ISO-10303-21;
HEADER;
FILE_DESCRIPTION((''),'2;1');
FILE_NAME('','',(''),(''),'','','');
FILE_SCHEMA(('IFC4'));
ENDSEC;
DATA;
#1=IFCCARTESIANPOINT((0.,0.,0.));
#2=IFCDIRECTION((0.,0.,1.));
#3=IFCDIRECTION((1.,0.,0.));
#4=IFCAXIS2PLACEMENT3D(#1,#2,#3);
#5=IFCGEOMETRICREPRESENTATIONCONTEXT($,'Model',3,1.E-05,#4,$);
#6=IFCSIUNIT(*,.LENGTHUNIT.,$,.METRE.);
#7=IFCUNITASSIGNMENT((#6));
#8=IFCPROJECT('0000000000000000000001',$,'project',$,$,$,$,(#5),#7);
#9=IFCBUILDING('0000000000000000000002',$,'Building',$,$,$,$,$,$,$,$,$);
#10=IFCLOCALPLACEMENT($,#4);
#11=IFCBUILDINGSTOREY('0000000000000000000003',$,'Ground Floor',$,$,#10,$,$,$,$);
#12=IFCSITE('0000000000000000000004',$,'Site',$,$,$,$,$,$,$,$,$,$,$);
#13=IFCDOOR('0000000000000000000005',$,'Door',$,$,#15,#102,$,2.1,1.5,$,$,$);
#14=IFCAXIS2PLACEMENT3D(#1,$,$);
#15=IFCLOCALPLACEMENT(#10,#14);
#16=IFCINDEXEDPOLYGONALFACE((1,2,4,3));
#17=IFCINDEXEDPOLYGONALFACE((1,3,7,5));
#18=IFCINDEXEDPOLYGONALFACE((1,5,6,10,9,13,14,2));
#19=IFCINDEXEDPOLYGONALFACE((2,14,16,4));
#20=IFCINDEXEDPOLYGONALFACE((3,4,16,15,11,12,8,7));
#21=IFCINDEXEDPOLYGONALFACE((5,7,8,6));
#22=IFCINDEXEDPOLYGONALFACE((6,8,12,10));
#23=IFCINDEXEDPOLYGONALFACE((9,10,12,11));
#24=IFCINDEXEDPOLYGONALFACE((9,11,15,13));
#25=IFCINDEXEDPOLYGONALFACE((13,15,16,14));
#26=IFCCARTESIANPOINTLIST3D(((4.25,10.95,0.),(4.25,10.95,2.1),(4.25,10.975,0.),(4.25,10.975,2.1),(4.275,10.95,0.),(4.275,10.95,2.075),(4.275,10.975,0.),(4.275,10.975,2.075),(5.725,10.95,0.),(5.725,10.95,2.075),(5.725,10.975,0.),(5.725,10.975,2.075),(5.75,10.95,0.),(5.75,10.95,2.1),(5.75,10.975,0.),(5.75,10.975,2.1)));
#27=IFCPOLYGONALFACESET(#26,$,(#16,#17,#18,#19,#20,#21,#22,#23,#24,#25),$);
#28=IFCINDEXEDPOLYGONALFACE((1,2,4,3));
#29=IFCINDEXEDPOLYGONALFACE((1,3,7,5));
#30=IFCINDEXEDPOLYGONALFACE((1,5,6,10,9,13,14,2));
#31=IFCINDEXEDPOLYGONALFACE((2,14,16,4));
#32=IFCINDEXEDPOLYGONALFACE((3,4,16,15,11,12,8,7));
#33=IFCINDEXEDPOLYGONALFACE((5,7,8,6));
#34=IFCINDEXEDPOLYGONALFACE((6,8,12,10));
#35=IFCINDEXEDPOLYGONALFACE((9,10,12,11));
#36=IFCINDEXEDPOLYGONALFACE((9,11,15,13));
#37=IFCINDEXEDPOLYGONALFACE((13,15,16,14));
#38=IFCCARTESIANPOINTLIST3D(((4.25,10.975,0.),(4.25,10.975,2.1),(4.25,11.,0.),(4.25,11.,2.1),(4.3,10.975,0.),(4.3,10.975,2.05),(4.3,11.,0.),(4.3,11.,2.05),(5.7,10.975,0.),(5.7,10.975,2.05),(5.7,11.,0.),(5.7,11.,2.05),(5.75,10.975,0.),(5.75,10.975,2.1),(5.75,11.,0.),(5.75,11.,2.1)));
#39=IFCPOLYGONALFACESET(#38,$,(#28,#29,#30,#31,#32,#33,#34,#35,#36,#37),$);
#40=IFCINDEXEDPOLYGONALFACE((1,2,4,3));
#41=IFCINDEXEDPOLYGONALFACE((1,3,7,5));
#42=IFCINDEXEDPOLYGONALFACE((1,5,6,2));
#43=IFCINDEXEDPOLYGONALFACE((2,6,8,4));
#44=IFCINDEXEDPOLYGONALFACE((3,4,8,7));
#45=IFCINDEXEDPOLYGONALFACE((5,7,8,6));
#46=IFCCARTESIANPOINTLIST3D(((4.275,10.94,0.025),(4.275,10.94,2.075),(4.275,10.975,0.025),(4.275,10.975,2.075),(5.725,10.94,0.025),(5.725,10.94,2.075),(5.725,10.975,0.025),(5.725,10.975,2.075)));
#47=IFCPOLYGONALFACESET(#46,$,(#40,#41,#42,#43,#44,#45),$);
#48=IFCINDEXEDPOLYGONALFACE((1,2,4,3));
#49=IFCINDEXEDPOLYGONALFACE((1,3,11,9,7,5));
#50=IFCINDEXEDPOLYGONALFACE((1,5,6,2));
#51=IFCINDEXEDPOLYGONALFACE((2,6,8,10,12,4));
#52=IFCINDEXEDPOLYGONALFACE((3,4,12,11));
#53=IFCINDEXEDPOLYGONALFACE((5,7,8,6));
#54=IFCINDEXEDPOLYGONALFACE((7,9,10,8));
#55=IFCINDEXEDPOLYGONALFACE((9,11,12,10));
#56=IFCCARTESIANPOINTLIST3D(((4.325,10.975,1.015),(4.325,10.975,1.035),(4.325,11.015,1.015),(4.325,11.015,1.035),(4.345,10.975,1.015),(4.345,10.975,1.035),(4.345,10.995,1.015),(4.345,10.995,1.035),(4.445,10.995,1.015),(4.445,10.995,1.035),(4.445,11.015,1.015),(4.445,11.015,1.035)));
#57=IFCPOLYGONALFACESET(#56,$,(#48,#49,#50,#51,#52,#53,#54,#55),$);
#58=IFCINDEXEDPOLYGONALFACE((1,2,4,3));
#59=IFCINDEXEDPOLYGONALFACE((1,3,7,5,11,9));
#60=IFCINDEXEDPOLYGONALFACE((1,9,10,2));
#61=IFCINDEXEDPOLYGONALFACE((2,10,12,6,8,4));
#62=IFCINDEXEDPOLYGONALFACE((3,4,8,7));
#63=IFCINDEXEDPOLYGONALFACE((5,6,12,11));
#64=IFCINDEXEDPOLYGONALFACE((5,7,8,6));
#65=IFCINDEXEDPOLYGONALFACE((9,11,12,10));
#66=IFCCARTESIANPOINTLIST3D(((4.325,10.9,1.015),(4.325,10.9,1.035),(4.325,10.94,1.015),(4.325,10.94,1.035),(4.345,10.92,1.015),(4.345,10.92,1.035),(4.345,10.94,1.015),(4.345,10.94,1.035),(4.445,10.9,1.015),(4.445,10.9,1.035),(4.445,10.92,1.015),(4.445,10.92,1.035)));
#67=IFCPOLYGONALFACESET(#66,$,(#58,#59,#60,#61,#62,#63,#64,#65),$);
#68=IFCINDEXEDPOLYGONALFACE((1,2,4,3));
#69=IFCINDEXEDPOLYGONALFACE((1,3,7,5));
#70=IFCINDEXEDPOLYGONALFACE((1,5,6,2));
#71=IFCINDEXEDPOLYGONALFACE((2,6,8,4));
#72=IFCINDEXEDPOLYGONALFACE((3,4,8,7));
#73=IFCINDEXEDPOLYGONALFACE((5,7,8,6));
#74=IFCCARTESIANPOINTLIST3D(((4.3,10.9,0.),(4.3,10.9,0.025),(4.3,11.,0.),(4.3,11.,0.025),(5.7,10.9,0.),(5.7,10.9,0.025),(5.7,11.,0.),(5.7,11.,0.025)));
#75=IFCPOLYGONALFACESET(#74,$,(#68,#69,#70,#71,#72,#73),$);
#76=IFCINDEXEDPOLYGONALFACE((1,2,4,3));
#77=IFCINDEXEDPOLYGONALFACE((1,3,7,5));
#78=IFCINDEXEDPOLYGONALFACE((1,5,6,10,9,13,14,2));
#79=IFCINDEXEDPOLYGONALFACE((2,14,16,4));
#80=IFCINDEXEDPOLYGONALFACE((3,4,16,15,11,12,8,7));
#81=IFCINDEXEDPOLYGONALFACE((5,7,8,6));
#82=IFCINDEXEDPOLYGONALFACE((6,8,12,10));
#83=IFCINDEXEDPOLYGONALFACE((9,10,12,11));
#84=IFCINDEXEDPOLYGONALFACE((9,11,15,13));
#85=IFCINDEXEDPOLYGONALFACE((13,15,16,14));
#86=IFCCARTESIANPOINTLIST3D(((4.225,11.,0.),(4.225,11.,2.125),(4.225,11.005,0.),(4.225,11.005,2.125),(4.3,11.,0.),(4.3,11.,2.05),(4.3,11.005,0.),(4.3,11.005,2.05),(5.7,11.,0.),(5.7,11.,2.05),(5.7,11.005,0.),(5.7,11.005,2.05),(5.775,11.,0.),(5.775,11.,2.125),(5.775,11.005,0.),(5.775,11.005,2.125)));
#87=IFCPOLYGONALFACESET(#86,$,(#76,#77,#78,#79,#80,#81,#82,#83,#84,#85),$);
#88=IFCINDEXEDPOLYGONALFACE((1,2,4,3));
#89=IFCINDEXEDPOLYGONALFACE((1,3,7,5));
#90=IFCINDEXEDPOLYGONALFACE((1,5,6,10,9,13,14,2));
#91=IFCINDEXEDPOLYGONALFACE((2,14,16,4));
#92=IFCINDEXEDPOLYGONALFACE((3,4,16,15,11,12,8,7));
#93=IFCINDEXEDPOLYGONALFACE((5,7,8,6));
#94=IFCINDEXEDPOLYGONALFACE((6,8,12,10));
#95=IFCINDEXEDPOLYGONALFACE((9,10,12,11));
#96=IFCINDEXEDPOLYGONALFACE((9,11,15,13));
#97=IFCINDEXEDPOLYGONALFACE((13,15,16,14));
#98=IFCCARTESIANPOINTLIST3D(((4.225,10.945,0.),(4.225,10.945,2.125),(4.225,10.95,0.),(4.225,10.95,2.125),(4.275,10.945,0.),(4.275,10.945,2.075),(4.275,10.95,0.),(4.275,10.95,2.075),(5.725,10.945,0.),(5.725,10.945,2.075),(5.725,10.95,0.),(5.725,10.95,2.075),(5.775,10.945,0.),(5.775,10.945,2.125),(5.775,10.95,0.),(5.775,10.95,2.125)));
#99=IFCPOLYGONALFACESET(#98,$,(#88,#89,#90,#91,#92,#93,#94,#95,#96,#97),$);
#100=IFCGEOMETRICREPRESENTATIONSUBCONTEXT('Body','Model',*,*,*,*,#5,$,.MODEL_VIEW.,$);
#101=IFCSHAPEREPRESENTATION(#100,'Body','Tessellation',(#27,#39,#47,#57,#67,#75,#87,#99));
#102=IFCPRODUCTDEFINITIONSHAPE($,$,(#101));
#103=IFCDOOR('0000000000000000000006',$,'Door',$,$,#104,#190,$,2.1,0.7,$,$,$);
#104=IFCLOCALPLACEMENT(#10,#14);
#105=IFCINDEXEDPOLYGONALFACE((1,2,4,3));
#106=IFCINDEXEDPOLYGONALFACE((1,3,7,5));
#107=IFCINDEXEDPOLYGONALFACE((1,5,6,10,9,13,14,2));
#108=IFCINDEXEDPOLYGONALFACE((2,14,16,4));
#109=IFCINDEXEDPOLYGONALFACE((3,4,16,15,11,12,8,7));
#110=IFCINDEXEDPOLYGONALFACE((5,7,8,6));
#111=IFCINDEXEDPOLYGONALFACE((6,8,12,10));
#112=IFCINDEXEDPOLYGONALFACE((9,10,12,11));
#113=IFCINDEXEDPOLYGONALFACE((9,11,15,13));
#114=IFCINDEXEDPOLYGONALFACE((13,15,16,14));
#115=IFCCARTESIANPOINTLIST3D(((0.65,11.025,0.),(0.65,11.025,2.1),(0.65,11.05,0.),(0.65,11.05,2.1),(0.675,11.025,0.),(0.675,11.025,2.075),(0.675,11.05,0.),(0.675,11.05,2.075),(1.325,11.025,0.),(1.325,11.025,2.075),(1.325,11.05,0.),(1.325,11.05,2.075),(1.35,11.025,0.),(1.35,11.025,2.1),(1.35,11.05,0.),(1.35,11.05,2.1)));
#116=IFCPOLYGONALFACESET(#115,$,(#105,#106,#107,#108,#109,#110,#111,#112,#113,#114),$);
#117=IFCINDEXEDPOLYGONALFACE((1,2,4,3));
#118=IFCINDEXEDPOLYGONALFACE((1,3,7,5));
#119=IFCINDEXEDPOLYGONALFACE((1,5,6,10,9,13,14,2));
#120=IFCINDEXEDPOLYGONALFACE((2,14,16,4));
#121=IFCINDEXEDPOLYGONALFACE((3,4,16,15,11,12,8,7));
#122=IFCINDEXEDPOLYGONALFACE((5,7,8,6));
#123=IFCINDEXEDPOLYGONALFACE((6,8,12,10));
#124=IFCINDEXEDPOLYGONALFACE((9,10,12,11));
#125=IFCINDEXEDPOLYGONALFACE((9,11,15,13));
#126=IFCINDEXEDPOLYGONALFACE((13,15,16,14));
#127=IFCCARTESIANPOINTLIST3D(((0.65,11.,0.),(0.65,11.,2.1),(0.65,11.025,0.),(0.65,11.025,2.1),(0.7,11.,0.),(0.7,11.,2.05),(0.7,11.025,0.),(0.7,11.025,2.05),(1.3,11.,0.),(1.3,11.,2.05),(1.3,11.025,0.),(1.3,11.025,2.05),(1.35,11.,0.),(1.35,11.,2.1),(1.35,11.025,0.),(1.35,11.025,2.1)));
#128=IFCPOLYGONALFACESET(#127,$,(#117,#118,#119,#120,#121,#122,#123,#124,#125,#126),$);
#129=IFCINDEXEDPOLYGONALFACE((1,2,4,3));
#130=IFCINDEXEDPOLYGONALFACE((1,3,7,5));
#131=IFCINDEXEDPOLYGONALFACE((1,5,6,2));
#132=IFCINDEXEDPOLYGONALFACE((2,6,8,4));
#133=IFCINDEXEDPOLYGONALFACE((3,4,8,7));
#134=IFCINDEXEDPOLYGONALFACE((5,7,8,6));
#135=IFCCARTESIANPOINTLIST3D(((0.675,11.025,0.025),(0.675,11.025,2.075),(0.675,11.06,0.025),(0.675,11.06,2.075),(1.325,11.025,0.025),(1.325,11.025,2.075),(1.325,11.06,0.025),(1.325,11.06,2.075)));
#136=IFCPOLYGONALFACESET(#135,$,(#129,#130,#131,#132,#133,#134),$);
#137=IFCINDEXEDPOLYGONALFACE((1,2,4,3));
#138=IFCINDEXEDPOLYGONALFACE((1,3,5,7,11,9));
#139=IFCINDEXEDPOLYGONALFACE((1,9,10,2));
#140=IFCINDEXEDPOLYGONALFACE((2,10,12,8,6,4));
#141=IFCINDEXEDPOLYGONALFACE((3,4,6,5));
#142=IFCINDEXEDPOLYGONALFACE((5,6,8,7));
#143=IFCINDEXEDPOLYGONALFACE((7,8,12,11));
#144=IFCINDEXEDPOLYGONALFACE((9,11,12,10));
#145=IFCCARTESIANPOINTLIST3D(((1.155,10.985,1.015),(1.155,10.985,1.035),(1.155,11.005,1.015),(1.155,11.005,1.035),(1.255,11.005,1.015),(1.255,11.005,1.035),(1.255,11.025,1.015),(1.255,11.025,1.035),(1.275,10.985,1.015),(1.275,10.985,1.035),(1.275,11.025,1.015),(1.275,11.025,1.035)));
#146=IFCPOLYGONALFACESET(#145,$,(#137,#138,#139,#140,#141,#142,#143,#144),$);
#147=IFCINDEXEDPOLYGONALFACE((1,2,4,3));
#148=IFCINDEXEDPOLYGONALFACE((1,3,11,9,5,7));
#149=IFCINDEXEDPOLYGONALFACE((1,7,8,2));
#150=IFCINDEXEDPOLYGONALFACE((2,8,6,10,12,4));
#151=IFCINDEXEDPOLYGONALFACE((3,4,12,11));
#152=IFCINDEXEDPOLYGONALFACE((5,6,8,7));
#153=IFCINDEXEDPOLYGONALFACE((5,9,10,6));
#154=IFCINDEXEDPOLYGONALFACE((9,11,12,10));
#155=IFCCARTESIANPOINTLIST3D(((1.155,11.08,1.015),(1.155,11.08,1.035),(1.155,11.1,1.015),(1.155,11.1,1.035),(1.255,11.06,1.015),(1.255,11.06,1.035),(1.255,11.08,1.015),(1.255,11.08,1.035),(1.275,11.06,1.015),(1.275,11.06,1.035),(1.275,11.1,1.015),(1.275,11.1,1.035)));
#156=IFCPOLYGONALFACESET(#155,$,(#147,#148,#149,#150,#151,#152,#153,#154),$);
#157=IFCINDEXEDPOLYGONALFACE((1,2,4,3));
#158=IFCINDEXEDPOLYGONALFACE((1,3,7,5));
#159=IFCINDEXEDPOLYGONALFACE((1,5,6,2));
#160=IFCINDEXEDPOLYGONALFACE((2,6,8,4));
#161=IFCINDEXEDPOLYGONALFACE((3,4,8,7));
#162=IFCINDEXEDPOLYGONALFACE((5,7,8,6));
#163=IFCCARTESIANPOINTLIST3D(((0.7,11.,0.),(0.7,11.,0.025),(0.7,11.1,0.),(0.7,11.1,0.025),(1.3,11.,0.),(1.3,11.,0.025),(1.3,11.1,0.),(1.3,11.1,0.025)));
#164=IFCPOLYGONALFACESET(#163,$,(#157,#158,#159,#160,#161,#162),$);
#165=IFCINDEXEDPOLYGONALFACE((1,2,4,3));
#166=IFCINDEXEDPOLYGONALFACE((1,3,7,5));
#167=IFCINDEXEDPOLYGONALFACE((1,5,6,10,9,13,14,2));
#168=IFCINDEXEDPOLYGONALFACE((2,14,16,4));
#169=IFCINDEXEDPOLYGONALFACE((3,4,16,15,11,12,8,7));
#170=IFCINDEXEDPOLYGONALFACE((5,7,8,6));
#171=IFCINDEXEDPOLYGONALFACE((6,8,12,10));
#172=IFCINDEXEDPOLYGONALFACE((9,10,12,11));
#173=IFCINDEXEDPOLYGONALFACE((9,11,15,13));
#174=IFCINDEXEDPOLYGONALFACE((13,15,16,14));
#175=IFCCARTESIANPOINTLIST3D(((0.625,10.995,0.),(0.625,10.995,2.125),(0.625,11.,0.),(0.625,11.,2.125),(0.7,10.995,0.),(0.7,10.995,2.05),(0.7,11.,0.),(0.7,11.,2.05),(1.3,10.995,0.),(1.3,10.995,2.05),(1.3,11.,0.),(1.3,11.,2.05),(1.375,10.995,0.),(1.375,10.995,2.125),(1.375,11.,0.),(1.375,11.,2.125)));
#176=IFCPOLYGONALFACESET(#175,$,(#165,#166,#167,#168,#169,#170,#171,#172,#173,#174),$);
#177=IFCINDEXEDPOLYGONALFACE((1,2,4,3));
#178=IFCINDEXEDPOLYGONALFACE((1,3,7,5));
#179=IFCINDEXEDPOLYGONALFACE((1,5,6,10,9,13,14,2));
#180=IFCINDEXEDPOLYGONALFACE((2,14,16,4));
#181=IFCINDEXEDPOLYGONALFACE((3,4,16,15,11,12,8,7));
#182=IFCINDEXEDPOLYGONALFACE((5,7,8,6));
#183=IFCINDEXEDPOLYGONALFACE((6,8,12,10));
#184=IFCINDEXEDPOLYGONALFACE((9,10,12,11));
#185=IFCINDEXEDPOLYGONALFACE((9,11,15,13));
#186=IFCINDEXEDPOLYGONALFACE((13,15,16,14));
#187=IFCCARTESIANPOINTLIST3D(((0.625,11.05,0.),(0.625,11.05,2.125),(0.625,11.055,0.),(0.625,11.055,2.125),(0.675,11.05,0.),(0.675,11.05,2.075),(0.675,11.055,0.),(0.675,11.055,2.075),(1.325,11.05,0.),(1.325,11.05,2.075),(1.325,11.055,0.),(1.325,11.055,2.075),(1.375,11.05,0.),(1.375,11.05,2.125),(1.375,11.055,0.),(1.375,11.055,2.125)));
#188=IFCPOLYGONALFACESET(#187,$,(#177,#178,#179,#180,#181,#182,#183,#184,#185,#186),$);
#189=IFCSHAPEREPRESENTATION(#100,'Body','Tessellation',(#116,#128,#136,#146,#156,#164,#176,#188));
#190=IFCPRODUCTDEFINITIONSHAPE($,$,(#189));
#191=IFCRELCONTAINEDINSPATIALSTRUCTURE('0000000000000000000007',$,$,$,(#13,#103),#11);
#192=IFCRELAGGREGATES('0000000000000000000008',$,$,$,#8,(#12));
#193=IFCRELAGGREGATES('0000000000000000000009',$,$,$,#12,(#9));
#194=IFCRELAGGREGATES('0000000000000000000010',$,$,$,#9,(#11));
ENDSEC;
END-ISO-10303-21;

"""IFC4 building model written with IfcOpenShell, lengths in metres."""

from ifc_helpers import new_model, si_unit, frame, origin_with_axes, place, context, subcontext, project, spatial, line, indexed_curve, outline, extrude, element, save


model = new_model("IFC4")

# Units and contexts
model_context = context("Model", 3, precision=1e-05, world=origin_with_axes())
body_context = subcontext(model_context, "Body", "Model", "MODEL_VIEW")
ifc_project = project(units=[si_unit("LENGTHUNIT", "METRE")], contexts=[model_context])

# Site, building, storey
site = spatial("IfcSite", under=ifc_project, Name="Site")
building = spatial("IfcBuilding", under=site, Name="Building")
storey_placement = place(None, origin_with_axes())
storey = spatial("IfcBuildingStorey", under=building, at=storey_placement, Name="Ground Floor")

# Doors
door_1_placement = place(storey_placement, frame((5.75, 11.0, 0.0), z_axis=(0.0, 0.0, 1.0), x_axis=(-1.0, 0.0, 0.0)))
element("IfcDoor", 1, at=door_1_placement, inside=storey, Name="Door", OverallHeight=2.1, OverallWidth=1.5, context=body_context, shape_type="SweptSolid", body=[
    extrude(outline(indexed_curve([(0.0, 0.0), (0.0, 2.1), (1.5, 2.1), (1.5, 0.0), (1.475, 0.0), (1.475, 2.075), (0.025, 2.075), (0.025, 0.0)], segments=[line(1, 2, 3, 4, 5, 6, 7, 8, 1)])), frame((0.0, 0.025, 0.0), z_axis=(0.0, -1.0, 0.0), x_axis=(1.0, 0.0, 0.0)), (0.0, 0.0, -1.0), 0.025),
    extrude(outline(indexed_curve([(0.0, 0.0), (0.0, 2.1), (1.5, 2.1), (1.5, 0.0), (1.45, 0.0), (1.45, 2.05), (0.05, 2.05), (0.05, 0.0)], segments=[line(1, 2, 3, 4, 5, 6, 7, 8, 1)])), frame((0.0, 0.0, 0.0), z_axis=(0.0, -1.0, 0.0), x_axis=(1.0, 0.0, 0.0)), (0.0, 0.0, -1.0), 0.025),
    extrude(outline(indexed_curve([(0.0, 0.0), (1.45, 0.0), (1.45, 0.035), (0.0, 0.035)], segments=[line(1, 2, 3, 4, 1)])), frame((0.025, 0.025, 0.025), z_axis=(0.0, 0.0, 1.0), x_axis=(1.0, 0.0, 0.0)), (0.0, 0.0, 1.0), 2.05),
    extrude(outline(indexed_curve([(0.0, 0.0), (0.0, -0.04), (-0.12, -0.04), (-0.12, -0.02), (-0.02, -0.02), (-0.02, 0.0)], segments=[line(1, 2, 3, 4, 5, 6, 1)])), frame((1.425, 0.025, 1.015), z_axis=(0.0, 0.0, 1.0), x_axis=(1.0, 0.0, 0.0)), (0.0, 0.0, 1.0), 0.02),
    extrude(outline(indexed_curve([(0.0, 0.0), (0.0, 0.04), (-0.12, 0.04), (-0.12, 0.02), (-0.02, 0.02), (-0.02, 0.0)], segments=[line(1, 2, 3, 4, 5, 6, 1)])), frame((1.425, 0.06, 1.015), z_axis=(0.0, 0.0, 1.0), x_axis=(1.0, 0.0, 0.0)), (0.0, 0.0, 1.0), 0.02),
    extrude(outline(indexed_curve([(0.0, 0.0), (1.4, 0.0), (1.4, 0.1), (0.0, 0.1)], segments=[line(1, 2, 3, 4, 1)])), frame((0.05, 0.0, 0.0), z_axis=(0.0, 0.0, 1.0), x_axis=(1.0, 0.0, 0.0)), (0.0, 0.0, 1.0), 0.025),
    extrude(outline(indexed_curve([(0.0, 0.0), (0.0, 2.125), (1.55, 2.125), (1.55, 0.0), (1.475, 0.0), (1.475, 2.05), (0.075, 2.05), (0.075, 0.0)], segments=[line(1, 2, 3, 4, 5, 6, 7, 8, 1)])), frame((-0.025, -0.005, 0.0), z_axis=(0.0, -1.0, 0.0), x_axis=(1.0, 0.0, 0.0)), (0.0, 0.0, -1.0), 0.005),
    extrude(outline(indexed_curve([(0.0, 0.0), (0.0, 2.125), (1.55, 2.125), (1.55, 0.0), (1.5, 0.0), (1.5, 2.075), (0.05, 2.075), (0.05, 0.0)], segments=[line(1, 2, 3, 4, 5, 6, 7, 8, 1)])), frame((-0.025, 0.05, 0.0), z_axis=(0.0, -1.0, 0.0), x_axis=(1.0, 0.0, 0.0)), (0.0, 0.0, -1.0), 0.005),
])
door_2_placement = place(storey_placement, frame((0.65, 11.0, 0.0), z_axis=(0.0, 0.0, 1.0), x_axis=(1.0, 0.0, 0.0)))
element("IfcDoor", 2, at=door_2_placement, inside=storey, Name="Door", OverallHeight=2.1, OverallWidth=0.7, context=body_context, shape_type="SweptSolid", body=[
    extrude(outline(indexed_curve([(0.0, 0.0), (0.0, 2.1), (0.7, 2.1), (0.7, 0.0), (0.675, 0.0), (0.675, 2.075), (0.025, 2.075), (0.025, 0.0)], segments=[line(1, 2, 3, 4, 5, 6, 7, 8, 1)])), frame((0.0, 0.025, 0.0), z_axis=(0.0, -1.0, 0.0), x_axis=(1.0, 0.0, 0.0)), (0.0, 0.0, -1.0), 0.025),
    extrude(outline(indexed_curve([(0.0, 0.0), (0.0, 2.1), (0.7, 2.1), (0.7, 0.0), (0.65, 0.0), (0.65, 2.05), (0.05, 2.05), (0.05, 0.0)], segments=[line(1, 2, 3, 4, 5, 6, 7, 8, 1)])), frame((0.0, 0.0, 0.0), z_axis=(0.0, -1.0, 0.0), x_axis=(1.0, 0.0, 0.0)), (0.0, 0.0, -1.0), 0.025),
    extrude(outline(indexed_curve([(0.0, 0.0), (0.65, 0.0), (0.65, 0.035), (0.0, 0.035)], segments=[line(1, 2, 3, 4, 1)])), frame((0.025, 0.025, 0.025), z_axis=(0.0, 0.0, 1.0), x_axis=(1.0, 0.0, 0.0)), (0.0, 0.0, 1.0), 2.05),
    extrude(outline(indexed_curve([(0.0, 0.0), (0.0, -0.04), (-0.12, -0.04), (-0.12, -0.02), (-0.02, -0.02), (-0.02, 0.0)], segments=[line(1, 2, 3, 4, 5, 6, 1)])), frame((0.625, 0.025, 1.015), z_axis=(0.0, 0.0, 1.0), x_axis=(1.0, 0.0, 0.0)), (0.0, 0.0, 1.0), 0.02),
    extrude(outline(indexed_curve([(0.0, 0.0), (0.0, 0.04), (-0.12, 0.04), (-0.12, 0.02), (-0.02, 0.02), (-0.02, 0.0)], segments=[line(1, 2, 3, 4, 5, 6, 1)])), frame((0.625, 0.06, 1.015), z_axis=(0.0, 0.0, 1.0), x_axis=(1.0, 0.0, 0.0)), (0.0, 0.0, 1.0), 0.02),
    extrude(outline(indexed_curve([(0.0, 0.0), (0.6, 0.0), (0.6, 0.1), (0.0, 0.1)], segments=[line(1, 2, 3, 4, 1)])), frame((0.05, 0.0, 0.0), z_axis=(0.0, 0.0, 1.0), x_axis=(1.0, 0.0, 0.0)), (0.0, 0.0, 1.0), 0.025),
    extrude(outline(indexed_curve([(0.0, 0.0), (0.0, 2.125), (0.75, 2.125), (0.75, 0.0), (0.675, 0.0), (0.675, 2.05), (0.075, 2.05), (0.075, 0.0)], segments=[line(1, 2, 3, 4, 5, 6, 7, 8, 1)])), frame((-0.025, -0.005, 0.0), z_axis=(0.0, -1.0, 0.0), x_axis=(1.0, 0.0, 0.0)), (0.0, 0.0, -1.0), 0.005),
    extrude(outline(indexed_curve([(0.0, 0.0), (0.0, 2.125), (0.75, 2.125), (0.75, 0.0), (0.7, 0.0), (0.7, 2.075), (0.05, 2.075), (0.05, 0.0)], segments=[line(1, 2, 3, 4, 5, 6, 7, 8, 1)])), frame((-0.025, 0.05, 0.0), z_axis=(0.0, -1.0, 0.0), x_axis=(1.0, 0.0, 0.0)), (0.0, 0.0, -1.0), 0.005),
])

save(model, "model.ifc")
